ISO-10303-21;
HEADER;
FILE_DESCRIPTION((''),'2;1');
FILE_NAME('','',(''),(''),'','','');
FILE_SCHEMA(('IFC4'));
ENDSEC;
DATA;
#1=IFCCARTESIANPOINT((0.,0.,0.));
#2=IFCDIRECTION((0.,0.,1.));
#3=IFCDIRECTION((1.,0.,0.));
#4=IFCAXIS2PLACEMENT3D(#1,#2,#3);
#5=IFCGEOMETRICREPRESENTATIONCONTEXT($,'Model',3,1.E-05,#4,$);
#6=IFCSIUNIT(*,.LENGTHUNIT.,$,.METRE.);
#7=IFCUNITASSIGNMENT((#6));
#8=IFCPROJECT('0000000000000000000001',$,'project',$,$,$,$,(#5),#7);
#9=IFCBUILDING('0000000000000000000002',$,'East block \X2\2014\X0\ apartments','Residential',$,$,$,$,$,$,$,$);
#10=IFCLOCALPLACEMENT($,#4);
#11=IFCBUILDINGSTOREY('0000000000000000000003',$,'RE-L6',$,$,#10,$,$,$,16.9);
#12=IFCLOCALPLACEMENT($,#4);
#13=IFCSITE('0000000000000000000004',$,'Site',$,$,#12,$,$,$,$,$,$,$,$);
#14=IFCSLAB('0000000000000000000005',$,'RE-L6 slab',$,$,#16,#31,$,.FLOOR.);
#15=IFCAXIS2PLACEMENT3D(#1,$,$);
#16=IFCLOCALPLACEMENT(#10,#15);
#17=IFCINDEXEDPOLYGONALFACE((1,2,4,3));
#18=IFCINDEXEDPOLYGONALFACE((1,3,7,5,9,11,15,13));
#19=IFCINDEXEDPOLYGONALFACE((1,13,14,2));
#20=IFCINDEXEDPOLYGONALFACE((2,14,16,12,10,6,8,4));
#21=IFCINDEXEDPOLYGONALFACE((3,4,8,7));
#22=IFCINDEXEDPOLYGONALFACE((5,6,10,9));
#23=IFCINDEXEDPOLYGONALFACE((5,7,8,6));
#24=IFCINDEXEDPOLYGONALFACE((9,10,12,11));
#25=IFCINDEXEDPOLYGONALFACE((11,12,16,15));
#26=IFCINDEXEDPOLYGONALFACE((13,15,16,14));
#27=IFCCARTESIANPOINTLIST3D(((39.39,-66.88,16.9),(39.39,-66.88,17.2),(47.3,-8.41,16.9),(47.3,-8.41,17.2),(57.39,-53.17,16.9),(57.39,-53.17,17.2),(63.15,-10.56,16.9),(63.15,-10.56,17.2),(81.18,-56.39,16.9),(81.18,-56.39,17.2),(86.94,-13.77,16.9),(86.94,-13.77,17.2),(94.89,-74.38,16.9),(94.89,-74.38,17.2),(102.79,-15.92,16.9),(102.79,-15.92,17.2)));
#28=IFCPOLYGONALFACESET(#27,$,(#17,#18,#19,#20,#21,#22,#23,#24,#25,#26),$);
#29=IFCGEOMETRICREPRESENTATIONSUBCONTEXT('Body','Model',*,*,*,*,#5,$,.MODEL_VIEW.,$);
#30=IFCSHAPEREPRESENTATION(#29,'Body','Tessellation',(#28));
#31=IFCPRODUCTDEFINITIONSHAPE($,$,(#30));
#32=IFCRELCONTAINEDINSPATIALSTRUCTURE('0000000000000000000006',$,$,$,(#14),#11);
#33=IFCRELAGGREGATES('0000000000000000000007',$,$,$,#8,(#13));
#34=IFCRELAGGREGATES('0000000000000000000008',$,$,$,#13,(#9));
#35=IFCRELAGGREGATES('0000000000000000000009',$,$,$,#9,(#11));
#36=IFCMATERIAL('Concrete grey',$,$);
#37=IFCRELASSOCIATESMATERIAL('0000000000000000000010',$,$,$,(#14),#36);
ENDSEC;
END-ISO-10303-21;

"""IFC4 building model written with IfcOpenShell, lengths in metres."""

from ifc_helpers import new_model, si_unit, frame, origin_with_axes, place, context, subcontext, project, spatial, polyline, outline, extrude, material, element, save


model = new_model("IFC4")

# Units and contexts
model_context = context("Model", 3, precision=1e-05, world=origin_with_axes())
body_context = subcontext(model_context, "Body", "Model", "MODEL_VIEW")
ifc_project = project(units=[si_unit("LENGTHUNIT", "METRE")], contexts=[model_context])

# Site, building, storey
site_placement = place(None, origin_with_axes())
site = spatial("IfcSite", under=ifc_project, at=site_placement, Name="Site")
building = spatial("IfcBuilding", under=site, Name="East block — apartments", Description="Residential")
storey_placement = place(None, origin_with_axes())
storey = spatial("IfcBuildingStorey", under=building, at=storey_placement, Name="RE-L6", Elevation=16.9)

# Slab
ifc_material = material(Name="Concrete grey")
slab_placement = place(storey_placement, origin_with_axes())
element("IfcSlab", 1, at=slab_placement, inside=storey, material=ifc_material, Name="RE-L6 slab", PredefinedType="FLOOR", context=body_context, shape_type="SweptSolid", body=[
    extrude(outline(polyline([(39.39, -66.88), (94.89, -74.38), (102.79, -15.92), (86.94, -13.77), (81.18, -56.39), (57.39, -53.17), (63.15, -10.56), (47.3, -8.41), (39.39, -66.88)])), frame((0.0, 0.0, 16.9), z_axis=(0.0, 0.0, 1.0), x_axis=(1.0, 0.0, 0.0)), (0.0, 0.0, 1.0), 0.3),
])

save(model, "model.ifc")
